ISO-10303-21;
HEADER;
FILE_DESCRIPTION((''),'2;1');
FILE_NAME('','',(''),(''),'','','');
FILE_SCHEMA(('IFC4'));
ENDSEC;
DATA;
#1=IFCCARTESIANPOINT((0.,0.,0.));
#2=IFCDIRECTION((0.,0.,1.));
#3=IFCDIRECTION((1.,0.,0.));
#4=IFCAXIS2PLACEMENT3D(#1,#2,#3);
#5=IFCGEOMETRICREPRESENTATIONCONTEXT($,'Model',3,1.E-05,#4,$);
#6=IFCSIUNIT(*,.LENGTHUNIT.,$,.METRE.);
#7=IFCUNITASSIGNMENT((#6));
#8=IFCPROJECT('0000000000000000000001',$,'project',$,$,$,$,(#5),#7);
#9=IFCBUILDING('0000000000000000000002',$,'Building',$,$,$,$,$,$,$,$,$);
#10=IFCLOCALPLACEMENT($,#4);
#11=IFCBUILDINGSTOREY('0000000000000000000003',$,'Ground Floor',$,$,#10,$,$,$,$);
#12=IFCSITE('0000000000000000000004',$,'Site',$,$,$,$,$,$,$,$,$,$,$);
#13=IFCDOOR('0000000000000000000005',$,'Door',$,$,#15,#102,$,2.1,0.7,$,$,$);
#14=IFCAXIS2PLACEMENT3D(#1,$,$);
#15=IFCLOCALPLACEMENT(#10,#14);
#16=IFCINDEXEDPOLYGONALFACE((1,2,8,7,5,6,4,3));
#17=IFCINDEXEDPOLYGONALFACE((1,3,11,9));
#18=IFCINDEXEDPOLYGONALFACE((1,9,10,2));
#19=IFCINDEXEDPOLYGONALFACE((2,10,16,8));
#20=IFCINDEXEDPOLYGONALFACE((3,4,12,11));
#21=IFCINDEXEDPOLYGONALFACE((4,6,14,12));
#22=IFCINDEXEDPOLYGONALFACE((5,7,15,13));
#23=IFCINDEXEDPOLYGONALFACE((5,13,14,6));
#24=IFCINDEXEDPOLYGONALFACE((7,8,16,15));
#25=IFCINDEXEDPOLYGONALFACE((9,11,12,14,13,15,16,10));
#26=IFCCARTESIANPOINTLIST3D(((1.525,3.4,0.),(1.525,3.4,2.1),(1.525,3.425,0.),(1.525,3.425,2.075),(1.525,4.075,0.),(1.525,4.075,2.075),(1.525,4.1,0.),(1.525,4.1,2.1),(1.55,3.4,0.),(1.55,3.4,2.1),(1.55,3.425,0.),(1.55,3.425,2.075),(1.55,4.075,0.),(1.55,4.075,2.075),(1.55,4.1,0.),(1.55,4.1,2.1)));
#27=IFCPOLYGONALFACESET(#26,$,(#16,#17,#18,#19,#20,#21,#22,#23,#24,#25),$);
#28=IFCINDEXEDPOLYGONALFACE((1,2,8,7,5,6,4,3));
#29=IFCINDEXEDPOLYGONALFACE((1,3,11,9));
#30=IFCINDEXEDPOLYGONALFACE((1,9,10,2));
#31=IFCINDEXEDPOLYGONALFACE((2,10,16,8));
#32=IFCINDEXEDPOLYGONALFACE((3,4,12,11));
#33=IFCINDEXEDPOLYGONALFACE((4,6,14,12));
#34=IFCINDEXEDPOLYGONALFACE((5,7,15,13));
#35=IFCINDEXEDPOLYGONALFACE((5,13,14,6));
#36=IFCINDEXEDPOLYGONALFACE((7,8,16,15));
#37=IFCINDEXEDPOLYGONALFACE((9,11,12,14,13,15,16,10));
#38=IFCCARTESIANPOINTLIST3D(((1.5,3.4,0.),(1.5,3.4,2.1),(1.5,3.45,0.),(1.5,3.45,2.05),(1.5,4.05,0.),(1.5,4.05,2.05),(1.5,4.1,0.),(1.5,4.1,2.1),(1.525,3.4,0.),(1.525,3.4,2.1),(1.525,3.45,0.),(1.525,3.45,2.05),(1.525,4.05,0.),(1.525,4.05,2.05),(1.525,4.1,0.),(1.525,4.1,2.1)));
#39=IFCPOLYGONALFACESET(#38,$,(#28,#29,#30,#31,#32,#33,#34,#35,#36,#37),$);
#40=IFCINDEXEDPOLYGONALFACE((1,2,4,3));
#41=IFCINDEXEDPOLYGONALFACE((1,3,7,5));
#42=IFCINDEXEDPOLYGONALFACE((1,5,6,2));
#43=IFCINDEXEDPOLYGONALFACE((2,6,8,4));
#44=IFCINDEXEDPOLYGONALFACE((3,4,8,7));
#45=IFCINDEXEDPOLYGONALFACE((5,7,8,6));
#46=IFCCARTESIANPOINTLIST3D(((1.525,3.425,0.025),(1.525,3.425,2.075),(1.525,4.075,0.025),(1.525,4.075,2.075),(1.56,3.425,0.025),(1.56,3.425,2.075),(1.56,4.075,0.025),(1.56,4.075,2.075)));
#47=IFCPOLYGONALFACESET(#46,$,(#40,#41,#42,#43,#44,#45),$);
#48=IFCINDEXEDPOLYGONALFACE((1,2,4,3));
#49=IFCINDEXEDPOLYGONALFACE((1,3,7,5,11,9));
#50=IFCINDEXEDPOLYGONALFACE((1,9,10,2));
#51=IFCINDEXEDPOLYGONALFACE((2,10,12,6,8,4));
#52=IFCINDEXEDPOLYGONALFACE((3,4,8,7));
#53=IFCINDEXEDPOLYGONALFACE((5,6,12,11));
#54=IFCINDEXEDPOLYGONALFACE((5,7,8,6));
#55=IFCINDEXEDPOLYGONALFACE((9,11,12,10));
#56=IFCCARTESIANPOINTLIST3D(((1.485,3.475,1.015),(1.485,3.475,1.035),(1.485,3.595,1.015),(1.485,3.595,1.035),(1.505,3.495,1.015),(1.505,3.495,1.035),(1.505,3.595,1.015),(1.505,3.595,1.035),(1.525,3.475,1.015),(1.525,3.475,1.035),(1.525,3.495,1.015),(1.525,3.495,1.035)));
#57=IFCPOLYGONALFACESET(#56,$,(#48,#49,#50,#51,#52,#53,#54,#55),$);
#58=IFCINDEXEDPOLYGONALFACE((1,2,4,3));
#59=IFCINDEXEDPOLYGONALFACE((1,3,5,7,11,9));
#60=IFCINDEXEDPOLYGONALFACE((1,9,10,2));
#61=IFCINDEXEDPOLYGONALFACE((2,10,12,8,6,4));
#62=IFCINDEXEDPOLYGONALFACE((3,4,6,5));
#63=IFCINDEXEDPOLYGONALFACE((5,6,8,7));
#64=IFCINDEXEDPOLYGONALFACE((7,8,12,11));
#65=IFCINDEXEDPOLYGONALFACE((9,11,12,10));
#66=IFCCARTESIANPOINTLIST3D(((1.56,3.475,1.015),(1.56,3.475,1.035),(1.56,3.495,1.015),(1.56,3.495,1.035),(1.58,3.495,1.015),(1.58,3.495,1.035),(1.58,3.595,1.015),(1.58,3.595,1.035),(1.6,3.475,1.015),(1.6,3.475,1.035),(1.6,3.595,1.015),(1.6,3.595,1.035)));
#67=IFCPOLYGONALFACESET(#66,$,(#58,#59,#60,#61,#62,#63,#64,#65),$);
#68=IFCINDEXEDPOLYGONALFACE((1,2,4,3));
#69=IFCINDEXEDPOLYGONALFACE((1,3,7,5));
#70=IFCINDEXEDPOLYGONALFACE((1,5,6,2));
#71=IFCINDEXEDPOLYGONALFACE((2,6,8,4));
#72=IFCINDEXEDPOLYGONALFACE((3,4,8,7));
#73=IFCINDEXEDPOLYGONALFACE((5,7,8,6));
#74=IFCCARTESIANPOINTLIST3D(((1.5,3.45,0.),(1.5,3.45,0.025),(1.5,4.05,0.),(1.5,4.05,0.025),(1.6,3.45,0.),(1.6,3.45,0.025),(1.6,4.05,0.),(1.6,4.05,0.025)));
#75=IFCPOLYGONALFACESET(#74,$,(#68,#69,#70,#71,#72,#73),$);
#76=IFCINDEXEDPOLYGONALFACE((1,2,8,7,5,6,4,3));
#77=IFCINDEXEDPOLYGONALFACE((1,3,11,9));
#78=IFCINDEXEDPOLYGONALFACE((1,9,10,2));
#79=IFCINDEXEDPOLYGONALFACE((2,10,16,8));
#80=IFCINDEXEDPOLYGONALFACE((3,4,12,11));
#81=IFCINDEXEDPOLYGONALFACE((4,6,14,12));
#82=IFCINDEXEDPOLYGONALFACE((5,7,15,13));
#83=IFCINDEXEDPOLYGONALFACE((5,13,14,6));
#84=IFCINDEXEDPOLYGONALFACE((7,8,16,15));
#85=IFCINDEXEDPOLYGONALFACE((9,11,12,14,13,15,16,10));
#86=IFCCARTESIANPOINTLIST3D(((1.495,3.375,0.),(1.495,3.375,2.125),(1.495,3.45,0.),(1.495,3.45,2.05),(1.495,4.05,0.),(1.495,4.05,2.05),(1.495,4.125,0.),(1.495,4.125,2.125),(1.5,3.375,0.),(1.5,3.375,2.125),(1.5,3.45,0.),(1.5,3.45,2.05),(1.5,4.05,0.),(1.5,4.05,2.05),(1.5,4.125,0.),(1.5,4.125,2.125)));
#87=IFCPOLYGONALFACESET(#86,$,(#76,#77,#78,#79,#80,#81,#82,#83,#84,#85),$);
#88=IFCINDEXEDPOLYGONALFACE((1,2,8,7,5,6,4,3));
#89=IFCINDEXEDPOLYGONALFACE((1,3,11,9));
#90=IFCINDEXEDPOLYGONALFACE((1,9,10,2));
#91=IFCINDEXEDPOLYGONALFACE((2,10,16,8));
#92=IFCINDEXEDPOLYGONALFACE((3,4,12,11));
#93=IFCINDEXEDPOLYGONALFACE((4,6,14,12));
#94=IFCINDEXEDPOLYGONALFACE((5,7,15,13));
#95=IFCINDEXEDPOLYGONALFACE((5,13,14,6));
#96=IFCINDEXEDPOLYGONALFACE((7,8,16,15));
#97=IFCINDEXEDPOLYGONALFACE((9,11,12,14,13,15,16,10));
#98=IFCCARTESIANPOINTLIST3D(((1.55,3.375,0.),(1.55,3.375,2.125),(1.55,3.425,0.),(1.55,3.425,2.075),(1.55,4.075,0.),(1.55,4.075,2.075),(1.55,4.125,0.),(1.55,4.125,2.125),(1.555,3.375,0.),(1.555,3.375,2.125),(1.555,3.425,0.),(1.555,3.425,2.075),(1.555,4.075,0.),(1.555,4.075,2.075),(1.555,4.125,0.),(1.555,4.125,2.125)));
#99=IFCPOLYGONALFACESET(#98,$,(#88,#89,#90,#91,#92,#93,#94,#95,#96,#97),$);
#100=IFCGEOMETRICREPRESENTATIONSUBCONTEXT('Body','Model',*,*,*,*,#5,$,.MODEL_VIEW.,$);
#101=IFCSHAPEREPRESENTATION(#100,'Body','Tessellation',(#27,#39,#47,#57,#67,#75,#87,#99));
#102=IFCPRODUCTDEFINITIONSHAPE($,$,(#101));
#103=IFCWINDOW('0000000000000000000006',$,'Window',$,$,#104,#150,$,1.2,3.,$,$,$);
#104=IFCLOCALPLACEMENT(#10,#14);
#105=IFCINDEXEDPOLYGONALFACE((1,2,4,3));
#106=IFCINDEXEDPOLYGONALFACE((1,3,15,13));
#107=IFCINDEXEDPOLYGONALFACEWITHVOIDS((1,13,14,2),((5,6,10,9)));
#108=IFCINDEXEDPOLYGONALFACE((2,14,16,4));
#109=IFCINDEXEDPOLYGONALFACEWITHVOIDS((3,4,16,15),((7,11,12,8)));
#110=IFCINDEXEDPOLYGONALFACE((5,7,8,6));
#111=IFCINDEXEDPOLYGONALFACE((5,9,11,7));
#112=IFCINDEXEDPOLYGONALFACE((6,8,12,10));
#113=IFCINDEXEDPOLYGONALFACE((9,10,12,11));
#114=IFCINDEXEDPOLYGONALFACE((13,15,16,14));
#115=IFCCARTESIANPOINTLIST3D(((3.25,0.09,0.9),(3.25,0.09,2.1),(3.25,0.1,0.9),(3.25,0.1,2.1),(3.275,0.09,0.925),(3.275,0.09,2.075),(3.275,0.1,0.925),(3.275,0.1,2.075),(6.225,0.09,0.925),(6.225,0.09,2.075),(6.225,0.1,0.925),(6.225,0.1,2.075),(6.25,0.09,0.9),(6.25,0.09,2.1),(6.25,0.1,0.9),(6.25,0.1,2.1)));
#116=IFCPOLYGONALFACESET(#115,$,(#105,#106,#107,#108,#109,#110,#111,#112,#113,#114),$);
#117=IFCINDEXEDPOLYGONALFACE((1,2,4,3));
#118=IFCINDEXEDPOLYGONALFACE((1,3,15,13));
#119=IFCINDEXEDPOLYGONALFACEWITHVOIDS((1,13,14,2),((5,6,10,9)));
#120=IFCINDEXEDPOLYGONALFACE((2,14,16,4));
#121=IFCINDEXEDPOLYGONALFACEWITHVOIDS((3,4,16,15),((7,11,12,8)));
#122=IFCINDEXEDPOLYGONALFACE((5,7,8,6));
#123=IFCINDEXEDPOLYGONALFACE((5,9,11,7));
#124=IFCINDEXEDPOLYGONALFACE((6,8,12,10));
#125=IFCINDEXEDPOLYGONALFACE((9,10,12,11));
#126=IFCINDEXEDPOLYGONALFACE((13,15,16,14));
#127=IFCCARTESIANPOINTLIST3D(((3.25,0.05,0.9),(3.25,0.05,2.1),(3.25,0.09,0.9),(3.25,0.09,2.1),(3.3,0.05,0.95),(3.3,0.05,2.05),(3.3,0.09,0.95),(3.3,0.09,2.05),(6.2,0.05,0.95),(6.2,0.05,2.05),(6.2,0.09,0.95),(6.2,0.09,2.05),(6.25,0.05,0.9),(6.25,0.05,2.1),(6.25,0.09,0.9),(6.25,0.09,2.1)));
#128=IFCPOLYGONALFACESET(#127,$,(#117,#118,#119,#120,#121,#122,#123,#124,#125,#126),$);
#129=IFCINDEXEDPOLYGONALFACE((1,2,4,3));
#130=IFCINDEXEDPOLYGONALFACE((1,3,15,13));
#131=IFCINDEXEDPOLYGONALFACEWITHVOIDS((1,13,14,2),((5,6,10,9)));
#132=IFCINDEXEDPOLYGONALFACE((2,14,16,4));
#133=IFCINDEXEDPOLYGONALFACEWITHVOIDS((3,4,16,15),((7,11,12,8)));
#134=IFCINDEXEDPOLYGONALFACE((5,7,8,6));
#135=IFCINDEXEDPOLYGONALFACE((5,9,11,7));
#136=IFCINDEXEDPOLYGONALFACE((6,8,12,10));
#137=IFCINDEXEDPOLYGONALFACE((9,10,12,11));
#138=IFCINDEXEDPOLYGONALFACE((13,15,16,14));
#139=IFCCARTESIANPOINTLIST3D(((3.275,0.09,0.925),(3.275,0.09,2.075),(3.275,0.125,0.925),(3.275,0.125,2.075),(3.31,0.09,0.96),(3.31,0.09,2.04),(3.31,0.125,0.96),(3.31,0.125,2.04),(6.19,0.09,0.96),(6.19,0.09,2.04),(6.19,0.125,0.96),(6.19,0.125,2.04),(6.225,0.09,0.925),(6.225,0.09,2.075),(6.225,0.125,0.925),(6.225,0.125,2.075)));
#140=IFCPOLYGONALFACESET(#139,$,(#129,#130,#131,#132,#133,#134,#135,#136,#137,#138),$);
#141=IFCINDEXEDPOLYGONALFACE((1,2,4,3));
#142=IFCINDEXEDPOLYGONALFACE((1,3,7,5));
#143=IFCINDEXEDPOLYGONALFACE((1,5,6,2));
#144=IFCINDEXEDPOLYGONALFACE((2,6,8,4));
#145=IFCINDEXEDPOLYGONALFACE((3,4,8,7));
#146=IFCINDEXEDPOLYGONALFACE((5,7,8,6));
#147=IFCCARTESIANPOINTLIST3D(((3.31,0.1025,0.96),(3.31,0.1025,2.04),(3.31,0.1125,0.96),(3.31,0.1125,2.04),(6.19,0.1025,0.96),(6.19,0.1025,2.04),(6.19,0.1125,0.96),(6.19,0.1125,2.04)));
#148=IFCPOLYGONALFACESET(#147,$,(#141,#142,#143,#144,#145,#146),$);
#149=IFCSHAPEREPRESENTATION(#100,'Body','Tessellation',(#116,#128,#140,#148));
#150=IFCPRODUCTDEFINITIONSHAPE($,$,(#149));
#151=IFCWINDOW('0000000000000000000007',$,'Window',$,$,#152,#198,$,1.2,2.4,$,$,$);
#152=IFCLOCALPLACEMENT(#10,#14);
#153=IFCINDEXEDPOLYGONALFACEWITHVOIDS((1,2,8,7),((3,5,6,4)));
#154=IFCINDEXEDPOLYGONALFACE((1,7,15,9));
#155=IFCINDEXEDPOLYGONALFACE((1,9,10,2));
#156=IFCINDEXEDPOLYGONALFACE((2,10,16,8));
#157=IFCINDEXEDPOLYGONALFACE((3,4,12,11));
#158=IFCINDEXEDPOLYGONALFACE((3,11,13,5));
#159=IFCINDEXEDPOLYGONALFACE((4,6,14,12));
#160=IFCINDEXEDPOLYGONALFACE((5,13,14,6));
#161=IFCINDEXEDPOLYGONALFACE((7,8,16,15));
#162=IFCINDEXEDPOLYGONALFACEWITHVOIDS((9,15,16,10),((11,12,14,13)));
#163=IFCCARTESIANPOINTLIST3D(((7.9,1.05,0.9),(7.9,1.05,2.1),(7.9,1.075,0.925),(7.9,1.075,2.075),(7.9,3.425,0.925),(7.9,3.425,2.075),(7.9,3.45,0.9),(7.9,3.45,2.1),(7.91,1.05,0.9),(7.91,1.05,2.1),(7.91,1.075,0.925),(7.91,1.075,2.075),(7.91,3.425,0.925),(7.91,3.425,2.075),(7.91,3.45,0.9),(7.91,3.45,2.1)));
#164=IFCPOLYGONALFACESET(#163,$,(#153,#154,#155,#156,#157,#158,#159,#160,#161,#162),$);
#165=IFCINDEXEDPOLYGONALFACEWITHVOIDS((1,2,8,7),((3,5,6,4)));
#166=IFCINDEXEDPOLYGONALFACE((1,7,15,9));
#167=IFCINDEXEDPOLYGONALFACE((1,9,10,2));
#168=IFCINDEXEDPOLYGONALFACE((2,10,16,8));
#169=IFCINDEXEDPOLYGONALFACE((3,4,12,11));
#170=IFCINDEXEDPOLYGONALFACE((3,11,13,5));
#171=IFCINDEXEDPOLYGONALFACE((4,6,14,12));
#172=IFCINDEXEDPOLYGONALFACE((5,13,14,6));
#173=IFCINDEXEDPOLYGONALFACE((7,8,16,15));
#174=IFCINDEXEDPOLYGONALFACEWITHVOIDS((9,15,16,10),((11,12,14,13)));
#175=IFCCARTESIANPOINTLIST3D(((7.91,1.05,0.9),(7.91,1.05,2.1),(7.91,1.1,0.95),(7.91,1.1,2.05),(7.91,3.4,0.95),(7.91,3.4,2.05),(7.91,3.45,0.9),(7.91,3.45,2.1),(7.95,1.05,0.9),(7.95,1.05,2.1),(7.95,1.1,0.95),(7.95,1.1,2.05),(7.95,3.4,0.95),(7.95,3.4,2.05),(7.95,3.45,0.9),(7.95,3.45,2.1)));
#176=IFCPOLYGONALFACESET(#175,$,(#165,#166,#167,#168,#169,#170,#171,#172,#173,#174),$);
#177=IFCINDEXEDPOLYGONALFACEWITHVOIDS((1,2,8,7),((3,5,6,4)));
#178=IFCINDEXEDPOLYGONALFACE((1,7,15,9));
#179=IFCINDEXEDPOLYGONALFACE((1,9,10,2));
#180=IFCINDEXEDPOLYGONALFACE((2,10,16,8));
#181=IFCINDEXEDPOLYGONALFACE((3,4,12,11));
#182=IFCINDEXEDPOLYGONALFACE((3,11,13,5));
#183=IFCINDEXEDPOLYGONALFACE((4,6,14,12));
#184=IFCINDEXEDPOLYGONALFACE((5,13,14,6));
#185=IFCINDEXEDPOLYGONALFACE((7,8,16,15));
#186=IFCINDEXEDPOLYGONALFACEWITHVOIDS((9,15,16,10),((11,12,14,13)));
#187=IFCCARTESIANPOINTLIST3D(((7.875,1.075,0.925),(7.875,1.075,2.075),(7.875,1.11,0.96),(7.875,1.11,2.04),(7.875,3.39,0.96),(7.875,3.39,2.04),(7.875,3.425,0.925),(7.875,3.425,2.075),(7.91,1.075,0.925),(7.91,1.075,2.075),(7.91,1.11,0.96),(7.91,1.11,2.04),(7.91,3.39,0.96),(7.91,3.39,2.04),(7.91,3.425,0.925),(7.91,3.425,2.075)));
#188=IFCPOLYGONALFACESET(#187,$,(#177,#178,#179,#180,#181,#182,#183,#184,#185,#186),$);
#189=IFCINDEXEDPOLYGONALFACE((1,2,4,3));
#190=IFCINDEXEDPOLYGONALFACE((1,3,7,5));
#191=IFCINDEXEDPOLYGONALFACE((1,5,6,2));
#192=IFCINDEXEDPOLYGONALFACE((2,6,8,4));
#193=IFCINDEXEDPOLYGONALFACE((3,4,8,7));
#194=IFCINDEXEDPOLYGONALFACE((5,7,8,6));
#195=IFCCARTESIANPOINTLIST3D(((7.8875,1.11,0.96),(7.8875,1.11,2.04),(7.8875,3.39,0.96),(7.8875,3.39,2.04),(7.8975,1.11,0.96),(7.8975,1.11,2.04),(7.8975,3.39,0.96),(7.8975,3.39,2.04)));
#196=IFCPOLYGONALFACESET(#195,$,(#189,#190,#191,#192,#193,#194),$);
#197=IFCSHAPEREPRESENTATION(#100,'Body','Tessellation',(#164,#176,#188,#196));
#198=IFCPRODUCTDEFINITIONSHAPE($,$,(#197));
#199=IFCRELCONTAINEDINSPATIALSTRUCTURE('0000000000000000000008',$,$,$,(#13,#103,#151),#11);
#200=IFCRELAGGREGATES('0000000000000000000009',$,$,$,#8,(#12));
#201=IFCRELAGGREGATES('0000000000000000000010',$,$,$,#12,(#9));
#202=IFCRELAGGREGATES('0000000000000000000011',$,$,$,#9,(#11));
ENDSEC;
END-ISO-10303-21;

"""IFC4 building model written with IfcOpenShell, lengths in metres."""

from ifc_helpers import new_model, si_unit, frame, origin_with_axes, place, context, subcontext, project, spatial, line, indexed_curve, outline, extrude, element, save


model = new_model("IFC4")

# Units and contexts
model_context = context("Model", 3, precision=1e-05, world=origin_with_axes())
body_context = subcontext(model_context, "Body", "Model", "MODEL_VIEW")
ifc_project = project(units=[si_unit("LENGTHUNIT", "METRE")], contexts=[model_context])

# Site, building, storey
site = spatial("IfcSite", under=ifc_project, Name="Site")
building = spatial("IfcBuilding", under=site, Name="Building")
storey_placement = place(None, origin_with_axes())
storey = spatial("IfcBuildingStorey", under=building, at=storey_placement, Name="Ground Floor")

# Door
door_1_placement = place(storey_placement, frame((1.5, 4.1, 0.0), z_axis=(0.0, 0.0, 1.0), x_axis=(0.0, -1.0, 0.0)))
element("IfcDoor", 1, at=door_1_placement, inside=storey, Name="Door", OverallHeight=2.1, OverallWidth=0.7, context=body_context, shape_type="SweptSolid", body=[
    extrude(outline(indexed_curve([(0.0, 0.0), (0.0, 2.1), (0.7, 2.1), (0.7, 0.0), (0.675, 0.0), (0.675, 2.075), (0.025, 2.075), (0.025, 0.0)], segments=[line(1, 2, 3, 4, 5, 6, 7, 8, 1)])), frame((0.0, 0.025, 0.0), z_axis=(0.0, -1.0, 0.0), x_axis=(1.0, 0.0, 0.0)), (0.0, 0.0, -1.0), 0.025),
    extrude(outline(indexed_curve([(0.0, 0.0), (0.0, 2.1), (0.7, 2.1), (0.7, 0.0), (0.65, 0.0), (0.65, 2.05), (0.05, 2.05), (0.05, 0.0)], segments=[line(1, 2, 3, 4, 5, 6, 7, 8, 1)])), frame((0.0, 0.0, 0.0), z_axis=(0.0, -1.0, 0.0), x_axis=(1.0, 0.0, 0.0)), (0.0, 0.0, -1.0), 0.025),
    extrude(outline(indexed_curve([(0.0, 0.0), (0.65, 0.0), (0.65, 0.035), (0.0, 0.035)], segments=[line(1, 2, 3, 4, 1)])), frame((0.025, 0.025, 0.025), z_axis=(0.0, 0.0, 1.0), x_axis=(1.0, 0.0, 0.0)), (0.0, 0.0, 1.0), 2.05),
    extrude(outline(indexed_curve([(0.0, 0.0), (0.0, -0.04), (-0.12, -0.04), (-0.12, -0.02), (-0.02, -0.02), (-0.02, 0.0)], segments=[line(1, 2, 3, 4, 5, 6, 1)])), frame((0.625, 0.025, 1.015), z_axis=(0.0, 0.0, 1.0), x_axis=(1.0, 0.0, 0.0)), (0.0, 0.0, 1.0), 0.02),
    extrude(outline(indexed_curve([(0.0, 0.0), (0.0, 0.04), (-0.12, 0.04), (-0.12, 0.02), (-0.02, 0.02), (-0.02, 0.0)], segments=[line(1, 2, 3, 4, 5, 6, 1)])), frame((0.625, 0.06, 1.015), z_axis=(0.0, 0.0, 1.0), x_axis=(1.0, 0.0, 0.0)), (0.0, 0.0, 1.0), 0.02),
    extrude(outline(indexed_curve([(0.0, 0.0), (0.6, 0.0), (0.6, 0.1), (0.0, 0.1)], segments=[line(1, 2, 3, 4, 1)])), frame((0.05, 0.0, 0.0), z_axis=(0.0, 0.0, 1.0), x_axis=(1.0, 0.0, 0.0)), (0.0, 0.0, 1.0), 0.025),
    extrude(outline(indexed_curve([(0.0, 0.0), (0.0, 2.125), (0.75, 2.125), (0.75, 0.0), (0.675, 0.0), (0.675, 2.05), (0.075, 2.05), (0.075, 0.0)], segments=[line(1, 2, 3, 4, 5, 6, 7, 8, 1)])), frame((-0.025, -0.005, 0.0), z_axis=(0.0, -1.0, 0.0), x_axis=(1.0, 0.0, 0.0)), (0.0, 0.0, -1.0), 0.005),
    extrude(outline(indexed_curve([(0.0, 0.0), (0.0, 2.125), (0.75, 2.125), (0.75, 0.0), (0.7, 0.0), (0.7, 2.075), (0.05, 2.075), (0.05, 0.0)], segments=[line(1, 2, 3, 4, 5, 6, 7, 8, 1)])), frame((-0.025, 0.05, 0.0), z_axis=(0.0, -1.0, 0.0), x_axis=(1.0, 0.0, 0.0)), (0.0, 0.0, -1.0), 0.005),
])

# Windows
window_1_placement = place(storey_placement, frame((3.25, 0.0, 0.9), z_axis=(0.0, 0.0, 1.0), x_axis=(1.0, 0.0, 0.0)))
element("IfcWindow", 2, at=window_1_placement, inside=storey, Name="Window", OverallHeight=1.2, OverallWidth=3.0, context=body_context, shape_type="SweptSolid", body=[
    extrude(outline(indexed_curve([(0.0, 0.0), (3.0, 0.0), (3.0, 1.2), (0.0, 1.2)], segments=[line(1, 2, 3, 4, 1)]), holes=[indexed_curve([(0.025, 0.025), (2.975, 0.025), (2.975, 1.175), (0.025, 1.175)], segments=[line(1, 2, 3, 4, 1)])]), frame((0.0, 0.09, 0.0), z_axis=(0.0, -1.0, 0.0), x_axis=(1.0, 0.0, 0.0)), (0.0, 0.0, -1.0), 0.01),
    extrude(outline(indexed_curve([(0.0, 0.0), (3.0, 0.0), (3.0, 1.2), (0.0, 1.2)], segments=[line(1, 2, 3, 4, 1)]), holes=[indexed_curve([(0.05, 0.05), (2.95, 0.05), (2.95, 1.15), (0.05, 1.15)], segments=[line(1, 2, 3, 4, 1)])]), frame((0.0, 0.05, 0.0), z_axis=(0.0, -1.0, 0.0), x_axis=(1.0, 0.0, 0.0)), (0.0, 0.0, -1.0), 0.04),
    extrude(outline(indexed_curve([(0.0, 0.0), (2.95, 0.0), (2.95, 1.15), (0.0, 1.15)], segments=[line(1, 2, 3, 4, 1)]), holes=[indexed_curve([(0.035, 0.035), (2.915, 0.035), (2.915, 1.115), (0.035, 1.115)], segments=[line(1, 2, 3, 4, 1)])]), frame((0.025, 0.09, 0.025), z_axis=(0.0, -1.0, 0.0), x_axis=(1.0, 0.0, 0.0)), (0.0, 0.0, -1.0), 0.035),
    extrude(outline(indexed_curve([(0.035, 0.035), (2.915, 0.035), (2.915, 1.115), (0.035, 1.115)], segments=[line(1, 2, 3, 4, 1)])), frame((0.025, 0.1025, 0.025), z_axis=(0.0, -1.0, 0.0), x_axis=(1.0, 0.0, 0.0)), (0.0, 0.0, -1.0), 0.01),
])
window_2_placement = place(storey_placement, frame((8.0, 1.05, 0.9), z_axis=(0.0, 0.0, 1.0), x_axis=(0.0, 1.0, 0.0)))
element("IfcWindow", 3, at=window_2_placement, inside=storey, Name="Window", OverallHeight=1.2, OverallWidth=2.4, context=body_context, shape_type="SweptSolid", body=[
    extrude(outline(indexed_curve([(0.0, 0.0), (2.4, 0.0), (2.4, 1.2), (0.0, 1.2)], segments=[line(1, 2, 3, 4, 1)]), holes=[indexed_curve([(0.025, 0.025), (2.375, 0.025), (2.375, 1.175), (0.025, 1.175)], segments=[line(1, 2, 3, 4, 1)])]), frame((0.0, 0.09, 0.0), z_axis=(0.0, -1.0, 0.0), x_axis=(1.0, 0.0, 0.0)), (0.0, 0.0, -1.0), 0.01),
    extrude(outline(indexed_curve([(0.0, 0.0), (2.4, 0.0), (2.4, 1.2), (0.0, 1.2)], segments=[line(1, 2, 3, 4, 1)]), holes=[indexed_curve([(0.05, 0.05), (2.35, 0.05), (2.35, 1.15), (0.05, 1.15)], segments=[line(1, 2, 3, 4, 1)])]), frame((0.0, 0.05, 0.0), z_axis=(0.0, -1.0, 0.0), x_axis=(1.0, 0.0, 0.0)), (0.0, 0.0, -1.0), 0.04),
    extrude(outline(indexed_curve([(0.0, 0.0), (2.35, 0.0), (2.35, 1.15), (0.0, 1.15)], segments=[line(1, 2, 3, 4, 1)]), holes=[indexed_curve([(0.035, 0.035), (2.315, 0.035), (2.315, 1.115), (0.035, 1.115)], segments=[line(1, 2, 3, 4, 1)])]), frame((0.025, 0.09, 0.025), z_axis=(0.0, -1.0, 0.0), x_axis=(1.0, 0.0, 0.0)), (0.0, 0.0, -1.0), 0.035),
    extrude(outline(indexed_curve([(0.035, 0.035), (2.315, 0.035), (2.315, 1.115), (0.035, 1.115)], segments=[line(1, 2, 3, 4, 1)])), frame((0.025, 0.1025, 0.025), z_axis=(0.0, -1.0, 0.0), x_axis=(1.0, 0.0, 0.0)), (0.0, 0.0, -1.0), 0.01),
])

save(model, "model.ifc")
